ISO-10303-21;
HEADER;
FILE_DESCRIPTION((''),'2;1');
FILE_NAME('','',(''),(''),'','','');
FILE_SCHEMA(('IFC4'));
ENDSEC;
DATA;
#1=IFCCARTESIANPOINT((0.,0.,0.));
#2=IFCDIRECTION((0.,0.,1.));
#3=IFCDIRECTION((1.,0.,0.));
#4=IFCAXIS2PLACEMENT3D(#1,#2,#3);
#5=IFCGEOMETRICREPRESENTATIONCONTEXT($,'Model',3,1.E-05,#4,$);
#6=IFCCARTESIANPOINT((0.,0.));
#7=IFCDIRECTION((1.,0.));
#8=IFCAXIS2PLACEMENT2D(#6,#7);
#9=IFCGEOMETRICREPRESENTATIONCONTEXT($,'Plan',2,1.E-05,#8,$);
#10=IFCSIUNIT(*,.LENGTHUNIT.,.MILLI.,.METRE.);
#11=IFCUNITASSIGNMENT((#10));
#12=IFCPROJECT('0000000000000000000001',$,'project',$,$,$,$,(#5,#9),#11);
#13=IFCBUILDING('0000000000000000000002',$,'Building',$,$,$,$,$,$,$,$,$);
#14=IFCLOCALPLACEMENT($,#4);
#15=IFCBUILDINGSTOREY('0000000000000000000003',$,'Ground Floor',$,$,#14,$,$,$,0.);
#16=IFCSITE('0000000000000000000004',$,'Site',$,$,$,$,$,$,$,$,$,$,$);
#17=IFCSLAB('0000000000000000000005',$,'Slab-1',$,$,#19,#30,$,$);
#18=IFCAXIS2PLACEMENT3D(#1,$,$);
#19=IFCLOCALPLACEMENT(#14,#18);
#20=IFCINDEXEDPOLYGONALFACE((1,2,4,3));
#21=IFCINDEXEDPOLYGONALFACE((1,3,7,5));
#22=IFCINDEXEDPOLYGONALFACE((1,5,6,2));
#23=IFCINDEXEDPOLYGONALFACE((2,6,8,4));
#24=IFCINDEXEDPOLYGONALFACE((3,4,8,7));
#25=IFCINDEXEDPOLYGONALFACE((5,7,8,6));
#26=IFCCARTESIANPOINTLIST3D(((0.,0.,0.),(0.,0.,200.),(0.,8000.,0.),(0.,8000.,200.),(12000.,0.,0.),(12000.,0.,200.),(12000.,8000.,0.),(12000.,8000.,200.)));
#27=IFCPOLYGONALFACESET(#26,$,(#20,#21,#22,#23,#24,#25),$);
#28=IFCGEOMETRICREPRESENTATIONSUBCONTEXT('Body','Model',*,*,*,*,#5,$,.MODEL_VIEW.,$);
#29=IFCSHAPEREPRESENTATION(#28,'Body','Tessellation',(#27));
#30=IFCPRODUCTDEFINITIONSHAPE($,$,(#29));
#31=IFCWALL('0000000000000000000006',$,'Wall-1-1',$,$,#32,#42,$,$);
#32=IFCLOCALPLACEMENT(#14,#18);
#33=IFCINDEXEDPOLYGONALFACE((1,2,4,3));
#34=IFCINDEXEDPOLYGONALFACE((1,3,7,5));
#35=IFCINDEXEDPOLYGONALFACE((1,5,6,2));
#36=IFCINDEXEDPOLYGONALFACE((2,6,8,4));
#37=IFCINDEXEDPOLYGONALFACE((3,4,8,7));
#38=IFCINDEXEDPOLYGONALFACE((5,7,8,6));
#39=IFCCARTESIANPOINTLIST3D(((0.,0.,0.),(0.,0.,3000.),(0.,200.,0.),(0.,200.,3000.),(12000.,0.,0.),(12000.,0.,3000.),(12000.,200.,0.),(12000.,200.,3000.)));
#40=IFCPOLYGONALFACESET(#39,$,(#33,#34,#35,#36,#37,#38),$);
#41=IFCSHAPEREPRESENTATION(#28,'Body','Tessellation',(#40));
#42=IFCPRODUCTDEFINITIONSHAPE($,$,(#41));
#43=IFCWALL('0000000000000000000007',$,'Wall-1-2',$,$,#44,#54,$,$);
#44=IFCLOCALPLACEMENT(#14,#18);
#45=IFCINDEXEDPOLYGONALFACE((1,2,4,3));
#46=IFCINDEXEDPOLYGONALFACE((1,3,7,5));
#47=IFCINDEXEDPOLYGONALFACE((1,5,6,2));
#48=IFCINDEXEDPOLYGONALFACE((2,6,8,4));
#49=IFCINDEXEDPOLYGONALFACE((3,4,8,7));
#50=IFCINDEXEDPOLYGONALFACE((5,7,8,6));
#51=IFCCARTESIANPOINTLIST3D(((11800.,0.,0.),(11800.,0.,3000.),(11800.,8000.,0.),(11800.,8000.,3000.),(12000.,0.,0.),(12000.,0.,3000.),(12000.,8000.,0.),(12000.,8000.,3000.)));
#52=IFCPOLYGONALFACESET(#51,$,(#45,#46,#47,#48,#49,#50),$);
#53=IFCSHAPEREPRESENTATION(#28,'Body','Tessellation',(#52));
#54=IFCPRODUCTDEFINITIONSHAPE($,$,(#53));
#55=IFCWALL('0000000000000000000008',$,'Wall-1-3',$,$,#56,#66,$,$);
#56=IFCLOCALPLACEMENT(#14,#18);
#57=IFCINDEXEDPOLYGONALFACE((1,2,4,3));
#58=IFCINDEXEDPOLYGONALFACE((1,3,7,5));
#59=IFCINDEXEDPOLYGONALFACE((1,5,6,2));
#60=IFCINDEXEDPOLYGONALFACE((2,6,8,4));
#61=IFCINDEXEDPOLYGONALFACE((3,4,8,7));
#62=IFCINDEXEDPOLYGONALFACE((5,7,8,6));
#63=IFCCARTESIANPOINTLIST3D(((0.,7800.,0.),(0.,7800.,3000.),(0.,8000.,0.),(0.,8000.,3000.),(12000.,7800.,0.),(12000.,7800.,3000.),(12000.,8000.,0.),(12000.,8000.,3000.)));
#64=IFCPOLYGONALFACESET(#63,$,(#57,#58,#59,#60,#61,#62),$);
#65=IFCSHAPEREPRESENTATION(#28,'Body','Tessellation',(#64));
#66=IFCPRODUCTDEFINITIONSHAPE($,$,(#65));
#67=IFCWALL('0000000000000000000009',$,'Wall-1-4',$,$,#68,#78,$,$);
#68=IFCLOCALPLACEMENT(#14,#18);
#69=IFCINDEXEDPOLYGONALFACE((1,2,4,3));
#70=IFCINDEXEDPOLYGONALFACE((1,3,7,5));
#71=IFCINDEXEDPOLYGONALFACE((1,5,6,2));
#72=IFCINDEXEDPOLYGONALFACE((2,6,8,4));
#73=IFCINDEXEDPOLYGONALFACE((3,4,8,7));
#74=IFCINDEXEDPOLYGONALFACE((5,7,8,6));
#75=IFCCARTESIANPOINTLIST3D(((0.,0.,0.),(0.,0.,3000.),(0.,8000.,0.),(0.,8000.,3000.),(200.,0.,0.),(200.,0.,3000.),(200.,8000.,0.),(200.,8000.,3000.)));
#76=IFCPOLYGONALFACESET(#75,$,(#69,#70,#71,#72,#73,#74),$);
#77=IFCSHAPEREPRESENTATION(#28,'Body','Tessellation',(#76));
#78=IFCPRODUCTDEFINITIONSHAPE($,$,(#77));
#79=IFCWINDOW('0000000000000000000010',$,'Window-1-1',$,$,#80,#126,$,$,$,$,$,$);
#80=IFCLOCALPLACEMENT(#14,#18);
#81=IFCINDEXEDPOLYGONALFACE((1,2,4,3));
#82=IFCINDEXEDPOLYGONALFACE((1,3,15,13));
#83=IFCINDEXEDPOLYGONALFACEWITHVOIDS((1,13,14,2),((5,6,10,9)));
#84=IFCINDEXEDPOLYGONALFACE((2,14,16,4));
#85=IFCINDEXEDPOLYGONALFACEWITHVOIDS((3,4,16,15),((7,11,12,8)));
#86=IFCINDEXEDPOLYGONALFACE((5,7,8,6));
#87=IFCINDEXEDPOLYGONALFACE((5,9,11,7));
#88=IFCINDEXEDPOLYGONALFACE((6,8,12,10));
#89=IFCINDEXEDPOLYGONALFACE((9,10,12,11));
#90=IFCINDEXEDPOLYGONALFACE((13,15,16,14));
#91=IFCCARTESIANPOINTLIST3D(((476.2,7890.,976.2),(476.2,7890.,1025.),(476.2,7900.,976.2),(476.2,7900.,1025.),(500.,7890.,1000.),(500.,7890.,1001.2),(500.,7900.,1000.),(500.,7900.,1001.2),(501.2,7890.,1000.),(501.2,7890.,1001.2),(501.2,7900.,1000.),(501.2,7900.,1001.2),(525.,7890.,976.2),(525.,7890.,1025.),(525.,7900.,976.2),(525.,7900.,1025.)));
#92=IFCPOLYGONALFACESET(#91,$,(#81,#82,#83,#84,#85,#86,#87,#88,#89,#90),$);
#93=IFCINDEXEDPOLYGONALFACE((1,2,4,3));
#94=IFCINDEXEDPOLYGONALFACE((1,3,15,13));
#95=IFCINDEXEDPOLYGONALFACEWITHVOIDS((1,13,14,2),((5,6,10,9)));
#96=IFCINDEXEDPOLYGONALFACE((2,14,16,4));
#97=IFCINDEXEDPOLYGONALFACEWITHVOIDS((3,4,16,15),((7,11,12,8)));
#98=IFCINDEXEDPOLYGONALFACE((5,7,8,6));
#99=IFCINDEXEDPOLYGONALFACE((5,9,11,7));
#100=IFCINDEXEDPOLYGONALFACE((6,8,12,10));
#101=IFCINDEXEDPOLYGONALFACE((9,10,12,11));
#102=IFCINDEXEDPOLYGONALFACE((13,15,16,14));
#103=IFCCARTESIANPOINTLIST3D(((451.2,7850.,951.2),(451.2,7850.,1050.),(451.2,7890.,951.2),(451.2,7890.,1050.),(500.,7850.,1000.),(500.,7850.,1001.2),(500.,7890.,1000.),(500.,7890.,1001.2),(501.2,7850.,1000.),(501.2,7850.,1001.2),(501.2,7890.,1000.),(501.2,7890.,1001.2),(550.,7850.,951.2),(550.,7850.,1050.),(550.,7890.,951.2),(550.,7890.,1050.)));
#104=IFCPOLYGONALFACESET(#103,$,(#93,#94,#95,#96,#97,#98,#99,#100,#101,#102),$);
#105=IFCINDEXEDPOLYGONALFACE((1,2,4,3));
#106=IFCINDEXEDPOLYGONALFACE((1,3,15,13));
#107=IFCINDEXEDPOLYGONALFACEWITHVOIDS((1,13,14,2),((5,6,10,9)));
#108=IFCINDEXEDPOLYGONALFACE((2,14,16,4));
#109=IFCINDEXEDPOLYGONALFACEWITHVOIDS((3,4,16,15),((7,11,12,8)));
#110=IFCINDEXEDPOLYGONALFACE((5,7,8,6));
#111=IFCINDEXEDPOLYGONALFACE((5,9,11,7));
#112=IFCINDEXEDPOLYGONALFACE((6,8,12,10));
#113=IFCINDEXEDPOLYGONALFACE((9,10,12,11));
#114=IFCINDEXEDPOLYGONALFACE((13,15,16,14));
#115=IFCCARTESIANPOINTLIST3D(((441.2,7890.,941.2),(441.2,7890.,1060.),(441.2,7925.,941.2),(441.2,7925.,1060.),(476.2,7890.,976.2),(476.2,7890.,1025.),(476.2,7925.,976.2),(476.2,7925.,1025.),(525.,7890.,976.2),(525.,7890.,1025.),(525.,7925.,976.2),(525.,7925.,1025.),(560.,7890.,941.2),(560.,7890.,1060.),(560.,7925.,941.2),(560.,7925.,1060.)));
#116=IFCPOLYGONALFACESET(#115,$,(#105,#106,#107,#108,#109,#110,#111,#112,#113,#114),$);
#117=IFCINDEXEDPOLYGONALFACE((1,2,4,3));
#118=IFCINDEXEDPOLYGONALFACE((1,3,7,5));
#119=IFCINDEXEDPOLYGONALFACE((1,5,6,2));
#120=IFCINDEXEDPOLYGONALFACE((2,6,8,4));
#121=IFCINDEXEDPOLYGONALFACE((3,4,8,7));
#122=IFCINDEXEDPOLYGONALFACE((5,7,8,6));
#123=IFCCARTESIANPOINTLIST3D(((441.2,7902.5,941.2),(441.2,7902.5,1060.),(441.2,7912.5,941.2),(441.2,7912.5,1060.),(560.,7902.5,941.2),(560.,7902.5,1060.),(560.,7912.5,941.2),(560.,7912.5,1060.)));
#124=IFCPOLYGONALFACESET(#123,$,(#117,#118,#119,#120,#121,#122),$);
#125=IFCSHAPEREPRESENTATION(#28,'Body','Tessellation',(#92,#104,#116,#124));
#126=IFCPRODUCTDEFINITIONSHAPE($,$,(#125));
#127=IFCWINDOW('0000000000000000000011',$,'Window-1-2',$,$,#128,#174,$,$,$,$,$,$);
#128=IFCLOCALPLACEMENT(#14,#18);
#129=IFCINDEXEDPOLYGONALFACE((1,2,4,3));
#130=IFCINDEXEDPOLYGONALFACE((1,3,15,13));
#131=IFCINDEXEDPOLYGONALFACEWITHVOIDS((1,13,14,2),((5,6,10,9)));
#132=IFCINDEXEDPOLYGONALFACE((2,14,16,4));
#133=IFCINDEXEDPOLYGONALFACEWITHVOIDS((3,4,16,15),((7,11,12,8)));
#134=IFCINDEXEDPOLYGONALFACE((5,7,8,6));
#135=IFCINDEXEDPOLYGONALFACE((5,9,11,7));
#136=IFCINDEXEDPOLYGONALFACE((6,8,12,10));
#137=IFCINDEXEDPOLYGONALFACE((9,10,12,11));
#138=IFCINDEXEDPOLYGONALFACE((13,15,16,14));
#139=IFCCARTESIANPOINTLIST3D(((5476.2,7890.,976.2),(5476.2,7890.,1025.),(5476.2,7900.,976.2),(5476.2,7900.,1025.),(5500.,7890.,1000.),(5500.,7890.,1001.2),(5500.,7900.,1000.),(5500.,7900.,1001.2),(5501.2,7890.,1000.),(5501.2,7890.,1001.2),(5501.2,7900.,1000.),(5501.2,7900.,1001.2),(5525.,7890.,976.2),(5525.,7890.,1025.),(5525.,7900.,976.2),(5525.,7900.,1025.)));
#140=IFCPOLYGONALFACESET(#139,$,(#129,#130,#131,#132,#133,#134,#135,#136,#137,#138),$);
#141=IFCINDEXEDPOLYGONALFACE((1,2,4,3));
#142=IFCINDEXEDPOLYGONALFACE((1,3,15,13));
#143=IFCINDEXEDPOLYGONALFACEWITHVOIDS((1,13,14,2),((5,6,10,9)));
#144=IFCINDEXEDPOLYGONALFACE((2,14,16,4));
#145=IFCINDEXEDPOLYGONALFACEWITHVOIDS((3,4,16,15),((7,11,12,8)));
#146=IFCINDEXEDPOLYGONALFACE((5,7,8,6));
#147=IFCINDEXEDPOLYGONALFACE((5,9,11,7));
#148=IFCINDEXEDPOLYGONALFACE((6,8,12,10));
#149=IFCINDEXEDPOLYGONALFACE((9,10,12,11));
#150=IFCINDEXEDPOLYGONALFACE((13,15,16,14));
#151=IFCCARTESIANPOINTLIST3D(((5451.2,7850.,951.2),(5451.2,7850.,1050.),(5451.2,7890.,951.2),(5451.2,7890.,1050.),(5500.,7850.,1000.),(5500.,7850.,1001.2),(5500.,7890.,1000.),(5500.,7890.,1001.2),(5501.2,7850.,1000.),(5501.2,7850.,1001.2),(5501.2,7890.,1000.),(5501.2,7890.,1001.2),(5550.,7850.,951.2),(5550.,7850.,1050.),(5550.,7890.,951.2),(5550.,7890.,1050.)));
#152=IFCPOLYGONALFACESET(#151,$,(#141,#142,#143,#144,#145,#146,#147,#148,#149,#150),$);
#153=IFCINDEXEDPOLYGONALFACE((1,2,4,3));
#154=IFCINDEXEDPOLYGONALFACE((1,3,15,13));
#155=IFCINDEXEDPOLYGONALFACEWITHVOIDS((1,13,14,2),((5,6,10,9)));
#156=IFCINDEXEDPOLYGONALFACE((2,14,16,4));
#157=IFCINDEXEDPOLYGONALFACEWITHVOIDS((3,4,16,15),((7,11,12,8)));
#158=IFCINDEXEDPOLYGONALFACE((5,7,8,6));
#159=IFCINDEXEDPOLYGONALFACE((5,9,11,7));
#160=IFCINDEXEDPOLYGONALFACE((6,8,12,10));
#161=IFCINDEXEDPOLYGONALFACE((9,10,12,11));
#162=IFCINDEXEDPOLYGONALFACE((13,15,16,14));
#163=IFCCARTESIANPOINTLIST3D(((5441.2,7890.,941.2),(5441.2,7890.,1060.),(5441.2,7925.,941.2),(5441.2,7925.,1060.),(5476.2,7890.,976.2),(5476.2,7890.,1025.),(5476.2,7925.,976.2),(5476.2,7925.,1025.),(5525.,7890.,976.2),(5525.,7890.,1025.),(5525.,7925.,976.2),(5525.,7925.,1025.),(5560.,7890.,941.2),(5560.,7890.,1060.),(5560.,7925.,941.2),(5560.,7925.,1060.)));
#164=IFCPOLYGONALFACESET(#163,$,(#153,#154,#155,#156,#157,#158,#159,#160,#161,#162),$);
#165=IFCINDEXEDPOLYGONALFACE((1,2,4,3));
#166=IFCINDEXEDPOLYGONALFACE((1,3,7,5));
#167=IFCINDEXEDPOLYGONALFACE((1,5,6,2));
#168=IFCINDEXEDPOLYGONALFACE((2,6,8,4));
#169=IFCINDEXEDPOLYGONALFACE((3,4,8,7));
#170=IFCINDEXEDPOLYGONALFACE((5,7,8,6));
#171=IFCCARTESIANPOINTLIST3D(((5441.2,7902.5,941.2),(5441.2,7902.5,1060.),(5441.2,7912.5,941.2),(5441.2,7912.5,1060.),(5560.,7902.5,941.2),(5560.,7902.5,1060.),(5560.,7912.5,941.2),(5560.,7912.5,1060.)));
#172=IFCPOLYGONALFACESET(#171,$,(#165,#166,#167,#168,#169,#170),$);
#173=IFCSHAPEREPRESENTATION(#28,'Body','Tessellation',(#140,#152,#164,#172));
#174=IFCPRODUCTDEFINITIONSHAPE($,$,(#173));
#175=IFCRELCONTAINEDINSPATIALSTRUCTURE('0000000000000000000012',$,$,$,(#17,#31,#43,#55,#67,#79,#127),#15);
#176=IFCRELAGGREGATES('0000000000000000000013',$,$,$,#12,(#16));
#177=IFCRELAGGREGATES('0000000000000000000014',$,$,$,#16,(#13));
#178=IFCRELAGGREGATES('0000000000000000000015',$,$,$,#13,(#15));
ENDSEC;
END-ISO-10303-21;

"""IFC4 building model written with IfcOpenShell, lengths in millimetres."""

from ifc_helpers import new_model, si_unit, frame, origin_with_axes, origin_2d_with_axis, place, context, subcontext, project, spatial, line, indexed_curve, outline, extrude, element, save


model = new_model("IFC4")

# Units and contexts
model_context = context("Model", 3, precision=1e-05, world=origin_with_axes())
plan_context = context("Plan", 2, precision=1e-05, world=origin_2d_with_axis())
body_context = subcontext(model_context, "Body", "Model", "MODEL_VIEW")
ifc_project = project(units=[si_unit("LENGTHUNIT", "METRE", prefix="MILLI")], contexts=[model_context, plan_context])

# Site, building, storey
site = spatial("IfcSite", under=ifc_project, Name="Site")
building = spatial("IfcBuilding", under=site, Name="Building")
storey_placement = place(None, origin_with_axes())
storey = spatial("IfcBuildingStorey", under=building, at=storey_placement, Name="Ground Floor", Elevation=0.0)

# Slab
slab_placement = place(storey_placement, origin_with_axes())
element("IfcSlab", 1, at=slab_placement, inside=storey, Name="Slab-1", context=body_context, shape_type="SweptSolid", body=[
    extrude(outline(indexed_curve([(0.0, 0.0), (12000.0, 0.0), (12000.0, 8000.0), (0.0, 8000.0), (0.0, 0.0)])), None, (0.0, 0.0, 1.0), 200.0),
])

# Walls
wall_1_placement = place(storey_placement, origin_with_axes())
element("IfcWall", 2, at=wall_1_placement, inside=storey, Name="Wall-1-1", context=body_context, shape_type="SweptSolid", body=[
    extrude(outline(indexed_curve([(0.0, 0.0), (0.0, 200.0), (12000.0, 200.0), (12000.0, 0.0), (0.0, 0.0)], self_intersect=False)), origin_with_axes(), (0.0, 0.0, 1.0), 3000.0),
])
wall_2_placement = place(storey_placement, frame((12000.0, 0.0, 0.0), z_axis=(0.0, 0.0, 1.0), x_axis=(0.0, 1.0, 0.0)))
element("IfcWall", 3, at=wall_2_placement, inside=storey, Name="Wall-1-2", context=body_context, shape_type="SweptSolid", body=[
    extrude(outline(indexed_curve([(0.0, 0.0), (0.0, 200.0), (8000.0, 200.0), (8000.0, 0.0), (0.0, 0.0)], self_intersect=False)), origin_with_axes(), (0.0, 0.0, 1.0), 3000.0),
])
wall_3_placement = place(storey_placement, frame((12000.0, 8000.0, 0.0), z_axis=(0.0, 0.0, 1.0), x_axis=(-1.0, 0.0, 0.0)))
element("IfcWall", 4, at=wall_3_placement, inside=storey, Name="Wall-1-3", context=body_context, shape_type="SweptSolid", body=[
    extrude(outline(indexed_curve([(0.0, 0.0), (0.0, 200.0), (12000.0, 200.0), (12000.0, 0.0), (0.0, 0.0)], self_intersect=False)), origin_with_axes(), (0.0, 0.0, 1.0), 3000.0),
])
wall_4_placement = place(storey_placement, frame((0.0, 8000.0, 0.0), z_axis=(0.0, 0.0, 1.0), x_axis=(0.0, -1.0, 0.0)))
element("IfcWall", 5, at=wall_4_placement, inside=storey, Name="Wall-1-4", context=body_context, shape_type="SweptSolid", body=[
    extrude(outline(indexed_curve([(0.0, 0.0), (0.0, 200.0), (8000.0, 200.0), (8000.0, 0.0), (0.0, 0.0)], self_intersect=False)), origin_with_axes(), (0.0, 0.0, 1.0), 3000.0),
])

# Windows
for number, where, z_axis, x_axis, name in (
    (6, (500.0, 7800.0, 1000.0), (0.0, 0.0, 1.0), (1.0, 0.0, 0.0), "Window-1-1"),
    (7, (5500.0, 7800.0, 1000.0), (0.0, 0.0, 1.0), (1.0, 0.0, 0.0), "Window-1-2"),
):
    element("IfcWindow", number, at=place(storey_placement, frame(where, z_axis=z_axis, x_axis=x_axis)), inside=storey, Name=name, context=body_context, shape_type="SweptSolid", body=[
        extrude(outline(indexed_curve([(0.0, 0.0), (1.2, 0.0), (1.2, 1.2), (0.0, 1.2)], segments=[line(1, 2, 3, 4, 1)]), holes=[indexed_curve([(25.0, 25.0), (-23.8, 25.0), (-23.8, -23.8), (25.0, -23.8)], segments=[line(1, 2, 3, 4, 1)])]), frame((0.0, 90.0, 0.0), z_axis=(0.0, -1.0, 0.0), x_axis=(1.0, 0.0, 0.0)), (0.0, 0.0, -1.0), 10.0),
        extrude(outline(indexed_curve([(0.0, 0.0), (1.2, 0.0), (1.2, 1.2), (0.0, 1.2)], segments=[line(1, 2, 3, 4, 1)]), holes=[indexed_curve([(50.0, 50.0), (-48.8, 50.0), (-48.8, -48.8), (50.0, -48.8)], segments=[line(1, 2, 3, 4, 1)])]), frame((0.0, 50.0, 0.0), z_axis=(0.0, -1.0, 0.0), x_axis=(1.0, 0.0, 0.0)), (0.0, 0.0, -1.0), 40.0),
        extrude(outline(indexed_curve([(0.0, 0.0), (-48.8, 0.0), (-48.8, -48.8), (0.0, -48.8)], segments=[line(1, 2, 3, 4, 1)]), holes=[indexed_curve([(35.0, 35.0), (-83.8, 35.0), (-83.8, -83.8), (35.0, -83.8)], segments=[line(1, 2, 3, 4, 1)])]), frame((25.0, 90.0, 25.0), z_axis=(0.0, -1.0, 0.0), x_axis=(1.0, 0.0, 0.0)), (0.0, 0.0, -1.0), 35.0),
        extrude(outline(indexed_curve([(35.0, 35.0), (-83.8, 35.0), (-83.8, -83.8), (35.0, -83.8)], segments=[line(1, 2, 3, 4, 1)])), frame((25.0, 102.5, 25.0), z_axis=(0.0, -1.0, 0.0), x_axis=(1.0, 0.0, 0.0)), (0.0, 0.0, -1.0), 10.0),
    ])

save(model, "model.ifc")
